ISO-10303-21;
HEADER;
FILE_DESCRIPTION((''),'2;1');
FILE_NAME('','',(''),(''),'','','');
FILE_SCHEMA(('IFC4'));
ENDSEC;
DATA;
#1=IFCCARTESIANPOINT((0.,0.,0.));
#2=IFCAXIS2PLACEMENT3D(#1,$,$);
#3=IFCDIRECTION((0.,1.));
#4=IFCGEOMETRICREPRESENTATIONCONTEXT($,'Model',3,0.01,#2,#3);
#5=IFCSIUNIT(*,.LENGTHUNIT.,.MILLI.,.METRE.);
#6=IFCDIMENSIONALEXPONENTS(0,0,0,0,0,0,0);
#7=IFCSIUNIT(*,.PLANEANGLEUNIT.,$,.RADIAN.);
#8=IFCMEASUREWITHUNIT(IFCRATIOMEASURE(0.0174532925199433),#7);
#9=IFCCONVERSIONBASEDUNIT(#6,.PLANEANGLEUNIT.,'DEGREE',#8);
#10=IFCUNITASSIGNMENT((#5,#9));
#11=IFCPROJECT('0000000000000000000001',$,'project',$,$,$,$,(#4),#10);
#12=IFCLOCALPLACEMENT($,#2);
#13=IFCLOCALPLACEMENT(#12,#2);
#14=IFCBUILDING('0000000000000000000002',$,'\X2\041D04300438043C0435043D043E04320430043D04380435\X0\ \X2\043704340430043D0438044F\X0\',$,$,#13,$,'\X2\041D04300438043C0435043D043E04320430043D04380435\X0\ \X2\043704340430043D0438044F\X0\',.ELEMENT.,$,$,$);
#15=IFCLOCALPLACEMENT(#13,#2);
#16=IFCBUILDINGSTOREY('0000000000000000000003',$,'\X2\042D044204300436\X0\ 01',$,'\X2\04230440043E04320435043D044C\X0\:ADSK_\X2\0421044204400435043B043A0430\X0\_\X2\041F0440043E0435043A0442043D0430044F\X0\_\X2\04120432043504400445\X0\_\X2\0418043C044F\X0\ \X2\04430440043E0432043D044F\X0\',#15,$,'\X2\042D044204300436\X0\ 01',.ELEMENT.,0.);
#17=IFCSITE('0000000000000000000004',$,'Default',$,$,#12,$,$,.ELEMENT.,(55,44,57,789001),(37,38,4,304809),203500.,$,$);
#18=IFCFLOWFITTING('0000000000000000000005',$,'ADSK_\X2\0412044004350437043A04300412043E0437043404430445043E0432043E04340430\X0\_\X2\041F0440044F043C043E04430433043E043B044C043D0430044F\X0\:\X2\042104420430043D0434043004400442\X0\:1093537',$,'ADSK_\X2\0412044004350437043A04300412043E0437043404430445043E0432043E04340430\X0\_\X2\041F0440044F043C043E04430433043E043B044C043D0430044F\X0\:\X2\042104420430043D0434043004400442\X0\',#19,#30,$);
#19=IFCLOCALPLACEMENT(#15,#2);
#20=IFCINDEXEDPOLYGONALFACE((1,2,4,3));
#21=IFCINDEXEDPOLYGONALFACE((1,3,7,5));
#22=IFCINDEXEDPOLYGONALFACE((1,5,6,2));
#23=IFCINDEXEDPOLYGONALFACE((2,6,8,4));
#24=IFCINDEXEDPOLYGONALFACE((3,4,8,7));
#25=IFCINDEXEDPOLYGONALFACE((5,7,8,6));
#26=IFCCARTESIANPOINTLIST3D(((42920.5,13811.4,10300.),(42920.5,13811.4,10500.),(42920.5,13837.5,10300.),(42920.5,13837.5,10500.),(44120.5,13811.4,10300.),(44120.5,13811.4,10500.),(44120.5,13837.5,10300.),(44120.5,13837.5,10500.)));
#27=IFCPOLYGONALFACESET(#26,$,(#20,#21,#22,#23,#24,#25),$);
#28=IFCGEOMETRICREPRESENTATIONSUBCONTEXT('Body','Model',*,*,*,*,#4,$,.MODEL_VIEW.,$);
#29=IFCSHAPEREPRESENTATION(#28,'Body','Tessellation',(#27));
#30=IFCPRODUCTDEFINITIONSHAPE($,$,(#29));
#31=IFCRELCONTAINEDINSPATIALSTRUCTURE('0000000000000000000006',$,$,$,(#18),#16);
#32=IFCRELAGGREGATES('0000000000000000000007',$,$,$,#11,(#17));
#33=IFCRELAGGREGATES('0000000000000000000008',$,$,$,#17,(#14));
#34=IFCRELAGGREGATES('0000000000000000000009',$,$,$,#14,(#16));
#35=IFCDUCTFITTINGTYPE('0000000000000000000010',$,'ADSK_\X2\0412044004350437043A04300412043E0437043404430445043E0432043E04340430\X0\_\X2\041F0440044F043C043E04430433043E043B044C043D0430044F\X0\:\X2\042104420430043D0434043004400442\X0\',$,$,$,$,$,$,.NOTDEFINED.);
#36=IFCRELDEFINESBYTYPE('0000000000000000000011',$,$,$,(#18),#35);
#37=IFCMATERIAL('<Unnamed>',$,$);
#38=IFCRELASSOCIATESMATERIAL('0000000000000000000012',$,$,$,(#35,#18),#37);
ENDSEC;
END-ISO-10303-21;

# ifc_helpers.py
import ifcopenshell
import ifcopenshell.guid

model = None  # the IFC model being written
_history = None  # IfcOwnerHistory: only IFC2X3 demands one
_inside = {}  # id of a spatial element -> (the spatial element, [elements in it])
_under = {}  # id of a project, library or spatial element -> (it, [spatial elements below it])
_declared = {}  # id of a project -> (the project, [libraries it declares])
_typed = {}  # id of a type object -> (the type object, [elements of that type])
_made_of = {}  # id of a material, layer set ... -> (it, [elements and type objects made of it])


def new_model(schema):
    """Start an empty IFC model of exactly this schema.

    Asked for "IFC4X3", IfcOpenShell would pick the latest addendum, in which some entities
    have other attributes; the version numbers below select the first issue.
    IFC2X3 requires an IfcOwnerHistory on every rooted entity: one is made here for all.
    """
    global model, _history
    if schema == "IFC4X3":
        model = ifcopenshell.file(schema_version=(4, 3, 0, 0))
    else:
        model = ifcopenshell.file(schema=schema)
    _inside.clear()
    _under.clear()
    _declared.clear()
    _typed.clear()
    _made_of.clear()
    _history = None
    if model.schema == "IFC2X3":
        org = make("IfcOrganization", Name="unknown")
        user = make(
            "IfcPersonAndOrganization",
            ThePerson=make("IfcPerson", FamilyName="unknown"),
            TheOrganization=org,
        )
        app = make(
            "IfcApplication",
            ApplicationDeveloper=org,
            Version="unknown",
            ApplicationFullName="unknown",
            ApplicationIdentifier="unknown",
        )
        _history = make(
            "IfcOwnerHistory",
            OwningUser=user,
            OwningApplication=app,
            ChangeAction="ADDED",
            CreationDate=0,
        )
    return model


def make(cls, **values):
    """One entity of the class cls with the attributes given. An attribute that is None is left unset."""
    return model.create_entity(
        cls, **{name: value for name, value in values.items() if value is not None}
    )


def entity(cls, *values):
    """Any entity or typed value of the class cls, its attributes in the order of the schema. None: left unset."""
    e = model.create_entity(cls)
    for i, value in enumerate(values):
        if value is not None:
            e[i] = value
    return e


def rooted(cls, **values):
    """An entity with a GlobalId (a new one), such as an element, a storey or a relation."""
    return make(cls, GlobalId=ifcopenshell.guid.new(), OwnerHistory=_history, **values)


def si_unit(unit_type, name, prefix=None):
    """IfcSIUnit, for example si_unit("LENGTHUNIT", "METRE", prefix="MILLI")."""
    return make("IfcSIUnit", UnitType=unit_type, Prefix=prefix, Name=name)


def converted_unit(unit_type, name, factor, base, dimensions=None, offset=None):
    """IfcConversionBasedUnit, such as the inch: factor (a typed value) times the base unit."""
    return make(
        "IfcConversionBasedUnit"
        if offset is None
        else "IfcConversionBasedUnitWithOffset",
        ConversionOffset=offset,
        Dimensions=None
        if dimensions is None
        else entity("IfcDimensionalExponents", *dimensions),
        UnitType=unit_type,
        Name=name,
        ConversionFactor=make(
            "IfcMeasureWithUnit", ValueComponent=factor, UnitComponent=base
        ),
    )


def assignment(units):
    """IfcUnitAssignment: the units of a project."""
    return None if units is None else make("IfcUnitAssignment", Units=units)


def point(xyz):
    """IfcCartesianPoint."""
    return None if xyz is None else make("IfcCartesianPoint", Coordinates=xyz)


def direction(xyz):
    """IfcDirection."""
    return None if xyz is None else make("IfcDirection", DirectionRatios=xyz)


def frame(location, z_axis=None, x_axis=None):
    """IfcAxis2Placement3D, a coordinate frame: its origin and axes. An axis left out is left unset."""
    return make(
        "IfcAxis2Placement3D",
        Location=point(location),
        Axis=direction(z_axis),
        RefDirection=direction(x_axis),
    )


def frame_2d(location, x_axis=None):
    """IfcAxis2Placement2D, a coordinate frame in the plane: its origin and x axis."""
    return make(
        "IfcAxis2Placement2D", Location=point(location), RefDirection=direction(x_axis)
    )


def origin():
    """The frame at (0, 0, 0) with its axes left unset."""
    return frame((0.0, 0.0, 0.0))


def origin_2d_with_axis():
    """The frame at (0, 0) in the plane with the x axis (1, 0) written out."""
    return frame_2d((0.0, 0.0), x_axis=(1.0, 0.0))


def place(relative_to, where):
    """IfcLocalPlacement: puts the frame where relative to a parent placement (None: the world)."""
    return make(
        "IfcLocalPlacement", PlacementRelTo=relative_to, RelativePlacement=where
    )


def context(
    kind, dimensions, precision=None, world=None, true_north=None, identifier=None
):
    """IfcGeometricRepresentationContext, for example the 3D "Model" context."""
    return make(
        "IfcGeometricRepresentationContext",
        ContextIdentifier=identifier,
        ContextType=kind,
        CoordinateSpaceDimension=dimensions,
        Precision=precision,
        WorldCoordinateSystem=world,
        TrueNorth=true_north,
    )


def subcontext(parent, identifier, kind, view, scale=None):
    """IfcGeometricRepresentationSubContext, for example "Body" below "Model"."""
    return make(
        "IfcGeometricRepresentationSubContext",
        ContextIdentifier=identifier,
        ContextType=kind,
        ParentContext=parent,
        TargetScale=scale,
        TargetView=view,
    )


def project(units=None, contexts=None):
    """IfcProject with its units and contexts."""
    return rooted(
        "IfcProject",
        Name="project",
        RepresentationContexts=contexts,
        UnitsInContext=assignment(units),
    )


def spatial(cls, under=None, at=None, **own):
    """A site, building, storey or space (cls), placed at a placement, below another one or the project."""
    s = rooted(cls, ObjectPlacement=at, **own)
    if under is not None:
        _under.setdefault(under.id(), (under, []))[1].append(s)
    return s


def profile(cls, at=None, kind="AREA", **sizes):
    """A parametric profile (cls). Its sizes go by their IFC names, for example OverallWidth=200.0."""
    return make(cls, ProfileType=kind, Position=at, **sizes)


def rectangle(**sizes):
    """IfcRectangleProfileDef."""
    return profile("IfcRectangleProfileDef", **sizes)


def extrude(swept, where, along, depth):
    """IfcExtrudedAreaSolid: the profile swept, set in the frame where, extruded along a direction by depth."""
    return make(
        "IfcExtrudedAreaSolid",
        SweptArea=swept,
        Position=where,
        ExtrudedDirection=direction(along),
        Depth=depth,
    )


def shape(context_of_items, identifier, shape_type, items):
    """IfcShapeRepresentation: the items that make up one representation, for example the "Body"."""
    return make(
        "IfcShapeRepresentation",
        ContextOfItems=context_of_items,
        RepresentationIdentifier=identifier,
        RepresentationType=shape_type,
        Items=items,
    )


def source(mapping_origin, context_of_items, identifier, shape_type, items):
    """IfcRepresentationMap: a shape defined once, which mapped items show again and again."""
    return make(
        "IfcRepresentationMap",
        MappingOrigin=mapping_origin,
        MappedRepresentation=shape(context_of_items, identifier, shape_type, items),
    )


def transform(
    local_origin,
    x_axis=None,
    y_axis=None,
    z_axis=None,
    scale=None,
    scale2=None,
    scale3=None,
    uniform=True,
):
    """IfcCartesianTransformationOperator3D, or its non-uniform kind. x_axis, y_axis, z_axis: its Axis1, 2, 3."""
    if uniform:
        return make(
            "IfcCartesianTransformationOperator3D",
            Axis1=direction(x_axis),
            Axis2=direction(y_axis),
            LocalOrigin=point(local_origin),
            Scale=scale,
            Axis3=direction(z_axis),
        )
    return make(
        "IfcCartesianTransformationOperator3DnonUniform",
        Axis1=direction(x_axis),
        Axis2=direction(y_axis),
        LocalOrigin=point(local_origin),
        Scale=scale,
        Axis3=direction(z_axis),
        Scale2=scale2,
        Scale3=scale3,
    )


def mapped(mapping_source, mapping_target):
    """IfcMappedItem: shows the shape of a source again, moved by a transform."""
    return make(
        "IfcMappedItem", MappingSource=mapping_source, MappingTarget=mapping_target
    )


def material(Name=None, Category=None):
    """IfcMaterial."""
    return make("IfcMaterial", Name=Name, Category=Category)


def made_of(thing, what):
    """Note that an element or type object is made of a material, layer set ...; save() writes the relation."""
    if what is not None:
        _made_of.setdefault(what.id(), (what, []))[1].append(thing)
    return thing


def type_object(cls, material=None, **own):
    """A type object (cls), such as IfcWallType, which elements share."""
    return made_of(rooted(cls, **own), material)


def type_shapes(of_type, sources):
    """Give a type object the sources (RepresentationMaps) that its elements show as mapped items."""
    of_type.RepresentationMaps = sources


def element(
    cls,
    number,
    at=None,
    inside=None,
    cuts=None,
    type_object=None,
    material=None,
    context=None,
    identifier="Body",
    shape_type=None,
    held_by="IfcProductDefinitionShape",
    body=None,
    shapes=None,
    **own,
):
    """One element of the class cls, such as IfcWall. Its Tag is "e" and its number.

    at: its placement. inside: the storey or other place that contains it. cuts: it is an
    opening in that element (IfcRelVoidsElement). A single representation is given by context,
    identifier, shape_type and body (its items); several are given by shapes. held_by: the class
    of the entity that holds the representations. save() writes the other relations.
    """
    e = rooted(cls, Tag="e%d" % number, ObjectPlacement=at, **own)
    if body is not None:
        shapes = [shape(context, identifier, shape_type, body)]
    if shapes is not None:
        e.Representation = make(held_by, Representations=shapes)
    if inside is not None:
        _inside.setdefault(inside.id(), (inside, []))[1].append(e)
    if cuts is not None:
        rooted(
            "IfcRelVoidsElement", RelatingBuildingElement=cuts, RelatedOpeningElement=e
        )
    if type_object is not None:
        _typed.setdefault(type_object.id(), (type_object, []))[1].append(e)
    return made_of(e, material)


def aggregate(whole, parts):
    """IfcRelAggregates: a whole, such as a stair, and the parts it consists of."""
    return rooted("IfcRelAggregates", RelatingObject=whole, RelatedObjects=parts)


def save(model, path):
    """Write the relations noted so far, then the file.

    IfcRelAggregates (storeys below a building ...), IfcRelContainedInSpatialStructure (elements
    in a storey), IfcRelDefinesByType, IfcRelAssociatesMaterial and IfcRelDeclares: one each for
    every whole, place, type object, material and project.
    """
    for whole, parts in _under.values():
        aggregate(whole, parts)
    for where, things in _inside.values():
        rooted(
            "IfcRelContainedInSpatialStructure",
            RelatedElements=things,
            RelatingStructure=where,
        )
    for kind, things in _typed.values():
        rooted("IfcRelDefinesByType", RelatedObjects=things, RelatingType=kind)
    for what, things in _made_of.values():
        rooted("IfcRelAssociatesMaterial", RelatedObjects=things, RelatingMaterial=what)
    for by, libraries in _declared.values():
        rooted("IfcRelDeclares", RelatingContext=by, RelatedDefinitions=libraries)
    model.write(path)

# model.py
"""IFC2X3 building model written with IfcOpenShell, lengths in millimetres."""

from ifc_helpers import new_model, entity, si_unit, converted_unit, direction, frame, origin, origin_2d_with_axis, place, context, subcontext, project, spatial, rectangle, extrude, source, transform, mapped, material, type_object, type_shapes, element, save


model = new_model("IFC2X3")

# Units and contexts
model_context = context("Model", 3, precision=0.01, world=origin(), true_north=direction((0.0, 1.0)))
body_context = subcontext(model_context, "Body", "Model", "MODEL_VIEW")
ifc_project = project(units=[si_unit("LENGTHUNIT", "METRE", prefix="MILLI"), converted_unit("PLANEANGLEUNIT", "DEGREE", entity("IfcRatioMeasure", 0.0174532925199433), si_unit("PLANEANGLEUNIT", "RADIAN"), dimensions=[0, 0, 0, 0, 0, 0, 0])], contexts=[model_context])

# Site, building, storey
site_placement = place(None, origin())
site = spatial("IfcSite", under=ifc_project, at=site_placement, Name="Default", CompositionType="ELEMENT", RefLatitude=(55, 44, 57, 789001), RefLongitude=(37, 38, 4, 304809), RefElevation=203500.0)
building_placement = place(site_placement, origin())
building = spatial("IfcBuilding", under=site, at=building_placement, Name="Наименование здания", LongName="Наименование здания", CompositionType="ELEMENT")
storey_placement = place(building_placement, origin())
storey = spatial("IfcBuildingStorey", under=building, at=storey_placement, Name="Этаж 01", ObjectType="Уровень:ADSK_Стрелка_Проектная_Вверх_Имя уровня", LongName="Этаж 01", CompositionType="ELEMENT", Elevation=0.0)

# Shared definitions
ifc_material_1 = material(Name="<Unnamed>")

# Flow fitting
duct_fitting_type_1 = type_object("IfcDuctFittingType", Name="ADSK_ВрезкаВоздуховода_Прямоугольная:Стандарт", PredefinedType="NOTDEFINED", material=ifc_material_1)
shared_shape_1 = source(origin(), body_context, "Body", "SweptSolid", [
    extrude(rectangle(XDim=26.1, YDim=1200.0, at=origin_2d_with_axis()), frame((7.0, 0.0, -100.0)), (0.0, 0.0, 1.0), 200.0),
])
type_shapes(duct_fitting_type_1, [shared_shape_1])
flow_fitting_1_placement = place(storey_placement, frame((43520.5, 13817.5, 10400.0), z_axis=(0.0, 0.0, -1.0), x_axis=(0.0, 1.0, 0.0)))
element("IfcFlowFitting", 1, at=flow_fitting_1_placement, inside=storey, type_object=duct_fitting_type_1, material=ifc_material_1, Name="ADSK_ВрезкаВоздуховода_Прямоугольная:Стандарт:1093537", ObjectType="ADSK_ВрезкаВоздуховода_Прямоугольная:Стандарт", context=body_context, shape_type="MappedRepresentation", body=[
    mapped(shared_shape_1, transform((0.0, 0.0, 0.0), scale=1.0)),
])

save(model, "model.ifc")
